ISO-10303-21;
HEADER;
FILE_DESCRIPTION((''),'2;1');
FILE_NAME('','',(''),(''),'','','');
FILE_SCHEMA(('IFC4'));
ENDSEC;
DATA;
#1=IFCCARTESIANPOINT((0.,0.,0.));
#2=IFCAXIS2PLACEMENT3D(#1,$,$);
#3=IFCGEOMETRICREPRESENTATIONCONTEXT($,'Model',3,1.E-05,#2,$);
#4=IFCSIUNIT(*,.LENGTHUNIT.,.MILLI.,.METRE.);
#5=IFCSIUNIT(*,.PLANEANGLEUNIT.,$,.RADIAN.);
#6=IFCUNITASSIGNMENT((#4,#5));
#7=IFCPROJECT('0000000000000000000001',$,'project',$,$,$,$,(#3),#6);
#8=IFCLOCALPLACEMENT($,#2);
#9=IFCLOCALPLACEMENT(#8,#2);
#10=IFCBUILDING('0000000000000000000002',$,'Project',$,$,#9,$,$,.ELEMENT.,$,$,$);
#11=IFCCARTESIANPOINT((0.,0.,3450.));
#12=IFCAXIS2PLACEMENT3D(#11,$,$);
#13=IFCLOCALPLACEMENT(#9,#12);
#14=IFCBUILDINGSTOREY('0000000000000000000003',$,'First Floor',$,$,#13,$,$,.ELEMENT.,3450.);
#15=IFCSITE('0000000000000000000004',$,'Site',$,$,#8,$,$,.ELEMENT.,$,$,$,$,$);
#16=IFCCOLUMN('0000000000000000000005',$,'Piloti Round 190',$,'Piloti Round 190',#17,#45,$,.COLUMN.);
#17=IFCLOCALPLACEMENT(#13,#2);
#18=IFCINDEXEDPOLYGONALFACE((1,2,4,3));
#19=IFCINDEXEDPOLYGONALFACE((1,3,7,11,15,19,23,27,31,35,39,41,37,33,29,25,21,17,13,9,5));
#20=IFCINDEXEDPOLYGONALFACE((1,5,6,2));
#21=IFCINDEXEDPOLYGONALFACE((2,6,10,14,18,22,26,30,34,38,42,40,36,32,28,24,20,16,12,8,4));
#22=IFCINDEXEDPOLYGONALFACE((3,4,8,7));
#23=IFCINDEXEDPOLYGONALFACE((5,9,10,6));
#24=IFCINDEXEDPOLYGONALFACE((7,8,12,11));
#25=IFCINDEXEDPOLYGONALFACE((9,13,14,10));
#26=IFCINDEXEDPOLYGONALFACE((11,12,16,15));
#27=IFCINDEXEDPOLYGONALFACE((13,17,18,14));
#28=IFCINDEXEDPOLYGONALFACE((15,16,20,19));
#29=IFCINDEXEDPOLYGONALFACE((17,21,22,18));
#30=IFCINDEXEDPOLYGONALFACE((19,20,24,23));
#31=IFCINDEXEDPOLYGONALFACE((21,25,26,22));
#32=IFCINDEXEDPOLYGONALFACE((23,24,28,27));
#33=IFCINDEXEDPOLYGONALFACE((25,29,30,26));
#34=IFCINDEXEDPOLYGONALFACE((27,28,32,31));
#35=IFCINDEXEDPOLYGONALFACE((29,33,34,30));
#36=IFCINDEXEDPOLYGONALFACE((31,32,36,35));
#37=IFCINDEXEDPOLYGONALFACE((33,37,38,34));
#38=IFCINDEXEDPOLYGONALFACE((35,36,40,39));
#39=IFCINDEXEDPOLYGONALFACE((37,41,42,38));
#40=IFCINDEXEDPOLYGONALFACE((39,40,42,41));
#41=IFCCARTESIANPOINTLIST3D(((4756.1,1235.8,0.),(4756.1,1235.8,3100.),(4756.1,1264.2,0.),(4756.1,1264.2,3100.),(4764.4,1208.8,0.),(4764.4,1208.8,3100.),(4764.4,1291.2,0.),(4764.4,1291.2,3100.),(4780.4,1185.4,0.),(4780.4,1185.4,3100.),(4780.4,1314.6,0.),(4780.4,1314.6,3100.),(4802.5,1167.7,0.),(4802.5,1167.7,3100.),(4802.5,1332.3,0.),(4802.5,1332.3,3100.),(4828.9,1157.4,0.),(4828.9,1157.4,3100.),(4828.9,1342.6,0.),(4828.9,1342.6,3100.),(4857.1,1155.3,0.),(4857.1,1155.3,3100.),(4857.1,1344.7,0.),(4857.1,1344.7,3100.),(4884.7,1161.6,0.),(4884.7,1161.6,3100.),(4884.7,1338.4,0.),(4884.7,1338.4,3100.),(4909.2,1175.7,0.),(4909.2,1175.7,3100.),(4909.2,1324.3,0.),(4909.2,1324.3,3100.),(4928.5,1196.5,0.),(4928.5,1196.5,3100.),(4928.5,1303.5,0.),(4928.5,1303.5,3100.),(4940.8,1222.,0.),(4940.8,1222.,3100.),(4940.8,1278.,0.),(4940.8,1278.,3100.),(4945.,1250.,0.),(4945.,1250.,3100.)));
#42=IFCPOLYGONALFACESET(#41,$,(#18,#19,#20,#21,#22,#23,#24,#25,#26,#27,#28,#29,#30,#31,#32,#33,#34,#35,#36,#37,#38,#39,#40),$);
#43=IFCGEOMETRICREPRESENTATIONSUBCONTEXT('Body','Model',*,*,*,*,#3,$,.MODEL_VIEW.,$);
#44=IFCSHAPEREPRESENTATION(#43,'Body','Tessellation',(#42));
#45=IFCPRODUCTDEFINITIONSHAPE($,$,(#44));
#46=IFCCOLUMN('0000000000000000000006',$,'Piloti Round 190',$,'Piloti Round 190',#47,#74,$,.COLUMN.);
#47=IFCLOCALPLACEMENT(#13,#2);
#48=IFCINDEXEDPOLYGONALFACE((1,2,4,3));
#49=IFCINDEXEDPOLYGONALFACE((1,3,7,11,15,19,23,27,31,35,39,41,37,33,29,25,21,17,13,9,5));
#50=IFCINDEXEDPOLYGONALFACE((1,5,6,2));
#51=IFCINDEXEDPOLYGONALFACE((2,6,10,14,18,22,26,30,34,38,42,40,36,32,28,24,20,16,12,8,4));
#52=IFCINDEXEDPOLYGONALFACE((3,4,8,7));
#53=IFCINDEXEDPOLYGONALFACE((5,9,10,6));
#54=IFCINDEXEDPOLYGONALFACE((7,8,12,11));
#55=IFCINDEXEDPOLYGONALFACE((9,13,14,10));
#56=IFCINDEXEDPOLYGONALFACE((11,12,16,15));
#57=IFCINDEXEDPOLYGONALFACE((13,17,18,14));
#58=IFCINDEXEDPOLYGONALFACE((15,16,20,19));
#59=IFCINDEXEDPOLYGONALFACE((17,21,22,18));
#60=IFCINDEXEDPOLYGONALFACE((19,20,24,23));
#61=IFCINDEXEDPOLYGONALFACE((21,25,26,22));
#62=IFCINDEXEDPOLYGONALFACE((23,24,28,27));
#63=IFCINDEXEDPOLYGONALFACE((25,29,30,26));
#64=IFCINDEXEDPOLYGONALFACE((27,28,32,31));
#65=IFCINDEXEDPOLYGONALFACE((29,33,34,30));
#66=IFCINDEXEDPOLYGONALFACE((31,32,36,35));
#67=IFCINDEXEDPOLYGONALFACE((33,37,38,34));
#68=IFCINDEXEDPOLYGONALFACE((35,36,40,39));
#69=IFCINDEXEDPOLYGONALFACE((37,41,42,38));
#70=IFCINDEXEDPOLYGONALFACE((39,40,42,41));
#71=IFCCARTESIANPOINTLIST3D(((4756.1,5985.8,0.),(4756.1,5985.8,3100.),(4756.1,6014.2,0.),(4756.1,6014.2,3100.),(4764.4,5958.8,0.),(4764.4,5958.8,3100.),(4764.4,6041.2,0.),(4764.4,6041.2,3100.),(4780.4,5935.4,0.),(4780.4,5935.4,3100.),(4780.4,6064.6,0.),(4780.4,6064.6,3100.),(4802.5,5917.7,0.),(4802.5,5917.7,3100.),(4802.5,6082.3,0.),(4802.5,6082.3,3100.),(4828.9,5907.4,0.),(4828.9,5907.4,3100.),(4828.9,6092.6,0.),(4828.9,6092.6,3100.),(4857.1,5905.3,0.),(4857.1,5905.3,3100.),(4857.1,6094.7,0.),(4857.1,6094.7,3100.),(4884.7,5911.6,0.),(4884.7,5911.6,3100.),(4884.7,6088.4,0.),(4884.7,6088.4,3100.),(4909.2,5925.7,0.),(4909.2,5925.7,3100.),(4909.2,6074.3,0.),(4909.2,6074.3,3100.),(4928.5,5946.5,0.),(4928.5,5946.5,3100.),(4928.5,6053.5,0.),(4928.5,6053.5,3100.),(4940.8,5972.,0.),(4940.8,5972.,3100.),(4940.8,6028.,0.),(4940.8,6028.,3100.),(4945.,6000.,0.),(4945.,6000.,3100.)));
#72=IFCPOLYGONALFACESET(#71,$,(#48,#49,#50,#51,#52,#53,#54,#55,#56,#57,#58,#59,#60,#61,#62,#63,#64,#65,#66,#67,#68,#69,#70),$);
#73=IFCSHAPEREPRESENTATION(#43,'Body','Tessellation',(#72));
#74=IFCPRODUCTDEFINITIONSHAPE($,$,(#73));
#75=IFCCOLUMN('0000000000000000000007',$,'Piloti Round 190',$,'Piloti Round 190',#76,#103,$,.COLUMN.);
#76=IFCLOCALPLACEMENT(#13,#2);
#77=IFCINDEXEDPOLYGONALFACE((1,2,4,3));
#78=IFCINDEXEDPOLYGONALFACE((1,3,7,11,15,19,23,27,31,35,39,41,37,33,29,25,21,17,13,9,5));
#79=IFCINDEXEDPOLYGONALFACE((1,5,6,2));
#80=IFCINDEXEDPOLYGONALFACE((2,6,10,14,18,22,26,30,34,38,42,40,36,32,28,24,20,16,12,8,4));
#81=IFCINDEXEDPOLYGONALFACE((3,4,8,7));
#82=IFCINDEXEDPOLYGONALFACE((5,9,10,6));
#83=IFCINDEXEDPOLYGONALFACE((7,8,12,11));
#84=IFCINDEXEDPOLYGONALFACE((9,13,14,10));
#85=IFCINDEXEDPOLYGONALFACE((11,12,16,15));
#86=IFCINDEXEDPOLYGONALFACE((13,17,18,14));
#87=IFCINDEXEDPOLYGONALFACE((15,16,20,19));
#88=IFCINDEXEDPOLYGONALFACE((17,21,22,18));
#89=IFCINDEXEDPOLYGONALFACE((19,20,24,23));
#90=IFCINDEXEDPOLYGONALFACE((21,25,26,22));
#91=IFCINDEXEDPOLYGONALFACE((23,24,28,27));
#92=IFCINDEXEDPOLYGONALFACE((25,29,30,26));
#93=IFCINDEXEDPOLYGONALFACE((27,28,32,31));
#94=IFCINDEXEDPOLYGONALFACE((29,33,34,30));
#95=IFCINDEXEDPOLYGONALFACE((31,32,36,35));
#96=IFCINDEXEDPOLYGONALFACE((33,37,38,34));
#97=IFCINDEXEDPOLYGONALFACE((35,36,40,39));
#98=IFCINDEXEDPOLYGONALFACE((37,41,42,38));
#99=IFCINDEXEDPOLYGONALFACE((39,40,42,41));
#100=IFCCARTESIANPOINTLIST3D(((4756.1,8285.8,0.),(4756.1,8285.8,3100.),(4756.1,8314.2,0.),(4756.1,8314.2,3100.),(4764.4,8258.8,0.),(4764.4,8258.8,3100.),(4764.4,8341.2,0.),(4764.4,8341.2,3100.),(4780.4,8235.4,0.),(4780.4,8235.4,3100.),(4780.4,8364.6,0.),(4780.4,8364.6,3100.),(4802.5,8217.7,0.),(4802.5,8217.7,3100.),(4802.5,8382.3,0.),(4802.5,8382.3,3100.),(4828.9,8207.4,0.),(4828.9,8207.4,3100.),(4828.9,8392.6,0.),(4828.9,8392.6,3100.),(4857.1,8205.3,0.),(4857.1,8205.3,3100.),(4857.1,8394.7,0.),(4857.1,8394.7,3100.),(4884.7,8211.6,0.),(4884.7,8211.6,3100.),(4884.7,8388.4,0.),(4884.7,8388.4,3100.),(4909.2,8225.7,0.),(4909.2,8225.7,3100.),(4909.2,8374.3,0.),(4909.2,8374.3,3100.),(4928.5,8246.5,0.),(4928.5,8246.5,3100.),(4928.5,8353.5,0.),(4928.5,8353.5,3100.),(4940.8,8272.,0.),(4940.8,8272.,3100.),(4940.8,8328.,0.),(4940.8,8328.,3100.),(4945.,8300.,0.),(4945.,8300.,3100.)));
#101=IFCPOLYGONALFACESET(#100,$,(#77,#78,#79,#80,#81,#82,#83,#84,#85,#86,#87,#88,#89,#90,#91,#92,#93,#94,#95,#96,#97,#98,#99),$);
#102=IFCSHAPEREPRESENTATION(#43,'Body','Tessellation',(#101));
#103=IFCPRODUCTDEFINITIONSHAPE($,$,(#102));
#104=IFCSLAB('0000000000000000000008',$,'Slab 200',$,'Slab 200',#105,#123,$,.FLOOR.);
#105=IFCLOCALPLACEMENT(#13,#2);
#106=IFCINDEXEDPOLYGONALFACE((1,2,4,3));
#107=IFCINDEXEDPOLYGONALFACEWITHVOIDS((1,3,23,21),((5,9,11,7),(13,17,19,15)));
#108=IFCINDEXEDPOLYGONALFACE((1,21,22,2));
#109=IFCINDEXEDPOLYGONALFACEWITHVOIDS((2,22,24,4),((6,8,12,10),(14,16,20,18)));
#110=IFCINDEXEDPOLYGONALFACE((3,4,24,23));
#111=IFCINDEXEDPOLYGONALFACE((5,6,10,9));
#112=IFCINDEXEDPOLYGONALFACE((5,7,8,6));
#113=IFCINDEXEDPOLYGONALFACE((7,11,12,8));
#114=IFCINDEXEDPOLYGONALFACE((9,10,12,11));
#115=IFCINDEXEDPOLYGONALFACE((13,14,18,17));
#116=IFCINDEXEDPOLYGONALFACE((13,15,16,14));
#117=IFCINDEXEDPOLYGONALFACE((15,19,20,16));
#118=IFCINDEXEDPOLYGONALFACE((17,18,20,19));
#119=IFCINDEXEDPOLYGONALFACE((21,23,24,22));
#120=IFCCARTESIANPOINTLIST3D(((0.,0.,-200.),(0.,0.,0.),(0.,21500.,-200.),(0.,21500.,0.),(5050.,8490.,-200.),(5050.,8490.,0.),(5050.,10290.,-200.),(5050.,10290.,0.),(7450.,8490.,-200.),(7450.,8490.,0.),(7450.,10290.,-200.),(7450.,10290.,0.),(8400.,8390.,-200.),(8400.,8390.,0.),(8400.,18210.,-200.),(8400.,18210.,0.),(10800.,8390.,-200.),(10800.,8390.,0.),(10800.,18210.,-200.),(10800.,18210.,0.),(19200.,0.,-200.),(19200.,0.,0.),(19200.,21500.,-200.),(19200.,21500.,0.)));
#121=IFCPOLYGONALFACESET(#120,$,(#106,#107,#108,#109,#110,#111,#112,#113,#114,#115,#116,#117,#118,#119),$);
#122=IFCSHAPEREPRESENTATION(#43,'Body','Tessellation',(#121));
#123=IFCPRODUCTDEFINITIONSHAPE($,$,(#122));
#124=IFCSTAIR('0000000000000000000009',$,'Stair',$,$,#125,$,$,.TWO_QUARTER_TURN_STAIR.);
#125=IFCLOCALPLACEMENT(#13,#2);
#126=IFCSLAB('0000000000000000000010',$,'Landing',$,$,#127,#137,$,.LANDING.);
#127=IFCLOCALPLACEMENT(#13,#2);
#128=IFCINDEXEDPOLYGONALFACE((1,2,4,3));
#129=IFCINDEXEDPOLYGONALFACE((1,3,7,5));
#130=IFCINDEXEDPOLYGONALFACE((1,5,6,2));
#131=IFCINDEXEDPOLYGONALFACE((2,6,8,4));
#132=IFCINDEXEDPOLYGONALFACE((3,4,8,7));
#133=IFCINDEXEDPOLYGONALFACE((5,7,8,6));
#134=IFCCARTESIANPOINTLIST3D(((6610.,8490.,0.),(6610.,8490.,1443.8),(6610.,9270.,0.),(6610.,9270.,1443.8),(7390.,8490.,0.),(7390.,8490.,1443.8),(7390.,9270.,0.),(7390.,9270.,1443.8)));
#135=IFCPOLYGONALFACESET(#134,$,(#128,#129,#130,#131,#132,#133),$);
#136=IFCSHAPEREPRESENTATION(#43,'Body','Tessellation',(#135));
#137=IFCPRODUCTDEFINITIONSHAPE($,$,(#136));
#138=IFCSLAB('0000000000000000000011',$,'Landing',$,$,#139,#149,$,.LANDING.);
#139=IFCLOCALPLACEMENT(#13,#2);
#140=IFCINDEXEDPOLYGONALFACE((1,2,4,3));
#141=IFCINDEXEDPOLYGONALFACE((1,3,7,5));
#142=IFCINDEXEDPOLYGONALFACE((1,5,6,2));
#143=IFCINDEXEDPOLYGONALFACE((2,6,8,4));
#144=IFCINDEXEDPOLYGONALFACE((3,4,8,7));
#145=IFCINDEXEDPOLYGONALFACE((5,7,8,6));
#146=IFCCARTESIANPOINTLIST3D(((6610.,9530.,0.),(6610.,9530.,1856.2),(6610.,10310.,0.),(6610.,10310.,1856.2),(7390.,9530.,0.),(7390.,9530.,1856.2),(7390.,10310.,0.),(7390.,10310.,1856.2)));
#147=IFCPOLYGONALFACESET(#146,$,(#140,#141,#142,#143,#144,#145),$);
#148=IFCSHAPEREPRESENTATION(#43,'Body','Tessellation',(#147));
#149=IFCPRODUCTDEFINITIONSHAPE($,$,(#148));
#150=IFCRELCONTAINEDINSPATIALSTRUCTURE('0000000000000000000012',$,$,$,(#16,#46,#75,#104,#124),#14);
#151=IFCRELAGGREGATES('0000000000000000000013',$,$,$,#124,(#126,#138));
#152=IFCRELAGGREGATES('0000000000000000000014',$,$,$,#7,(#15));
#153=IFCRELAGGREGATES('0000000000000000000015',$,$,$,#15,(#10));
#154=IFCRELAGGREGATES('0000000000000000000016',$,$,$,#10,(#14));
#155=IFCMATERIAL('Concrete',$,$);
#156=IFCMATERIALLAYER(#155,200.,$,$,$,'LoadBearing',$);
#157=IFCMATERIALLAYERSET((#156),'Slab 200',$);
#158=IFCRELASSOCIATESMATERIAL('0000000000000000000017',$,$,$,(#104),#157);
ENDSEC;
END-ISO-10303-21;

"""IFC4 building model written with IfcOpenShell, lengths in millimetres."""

from ifc_helpers import new_model, si_unit, frame, origin, origin_2d, place, context, subcontext, project, spatial, polyline, circle, outline, extrude, material, layer, layer_set, layer_usage, element, aggregate, save


model = new_model("IFC4")

# Units and contexts
model_context = context("Model", 3, precision=1e-05, world=origin())
body_context = subcontext(model_context, "Body", "Model", "MODEL_VIEW")
ifc_project = project(units=[si_unit("LENGTHUNIT", "METRE", prefix="MILLI"), si_unit("PLANEANGLEUNIT", "RADIAN")], contexts=[model_context])

# Site, building, storey
site_placement = place(None, origin())
site = spatial("IfcSite", under=ifc_project, at=site_placement, Name="Site", CompositionType="ELEMENT")
building_placement = place(site_placement, origin())
building = spatial("IfcBuilding", under=site, at=building_placement, Name="Project", CompositionType="ELEMENT")
storey_placement = place(building_placement, frame((0.0, 0.0, 3450.0)))
storey = spatial("IfcBuildingStorey", under=building, at=storey_placement, Name="First Floor", CompositionType="ELEMENT", Elevation=3450.0)

# Columns
for number, where, z_axis, x_axis, name in (
    (1, (4850.0, 1250.0, 0.0), (0.0, 0.0, 1.0), (1.0, 0.0, 0.0), "Piloti Round 190"),
    (2, (4850.0, 6000.0, 0.0), (0.0, 0.0, 1.0), (1.0, 0.0, 0.0), "Piloti Round 190"),
    (3, (4850.0, 8300.0, 0.0), (0.0, 0.0, 1.0), (1.0, 0.0, 0.0), "Piloti Round 190"),
):
    element("IfcColumn", number, at=place(storey_placement, frame(where, z_axis=z_axis, x_axis=x_axis)), inside=storey, Name=name, ObjectType="Piloti Round 190", PredefinedType="COLUMN", context=body_context, shape_type="SweptSolid", body=[
        extrude(circle(Radius=95.0, at=origin_2d()), origin(), (0.0, 0.0, 1.0), 3100.0),
    ])

# Slab
ifc_material = material(Name="Concrete")
ifc_layer_1 = layer(ifc_material, 200.0, Category="LoadBearing")
ifc_layer_set_1 = layer_set([ifc_layer_1], Name="Slab 200")
ifc_layer_usage_1 = layer_usage(ifc_layer_set_1, "AXIS3", "NEGATIVE", 0.0)
slab_1_placement = place(storey_placement, origin())
element("IfcSlab", 4, at=slab_1_placement, inside=storey, material=ifc_layer_usage_1, Name="Slab 200", ObjectType="Slab 200", PredefinedType="FLOOR", context=body_context, shape_type="SweptSolid", body=[
    extrude(outline(polyline([(0.0, 0.0), (19200.0, 0.0), (19200.0, 21500.0), (0.0, 21500.0), (0.0, 0.0)]), holes=[polyline([(8400.0, 8390.0), (10800.0, 8390.0), (10800.0, 18210.0), (8400.0, 18210.0), (8400.0, 8390.0)]), polyline([(5050.0, 8490.0), (7450.0, 8490.0), (7450.0, 10290.0), (5050.0, 10290.0), (5050.0, 8490.0)])]), frame((0.0, 0.0, -200.0)), (0.0, 0.0, 1.0), 200.0),
])

# Stair, slabs
stair_placement = place(storey_placement, origin())
stair = element("IfcStair", 5, at=stair_placement, inside=storey, Name="Stair", PredefinedType="TWO_QUARTER_TURN_STAIR")
slab_2_placement = place(stair_placement, origin())
slab_2 = element("IfcSlab", 6, at=slab_2_placement, Name="Landing", PredefinedType="LANDING", context=body_context, shape_type="SweptSolid", body=[
    extrude(outline(polyline([(6610.0, 8490.0), (7390.0, 8490.0), (7390.0, 9270.0), (6610.0, 9270.0), (6610.0, 8490.0)])), origin(), (0.0, 0.0, 1.0), 1443.8),
])
slab_3_placement = place(stair_placement, origin())
slab_3 = element("IfcSlab", 7, at=slab_3_placement, Name="Landing", PredefinedType="LANDING", context=body_context, shape_type="SweptSolid", body=[
    extrude(outline(polyline([(7390.0, 9530.0), (7390.0, 10310.0), (6610.0, 10310.0), (6610.0, 9530.0), (7390.0, 9530.0)])), origin(), (0.0, 0.0, 1.0), 1856.2),
])
aggregate(stair, [slab_2, slab_3])

save(model, "model.ifc")
